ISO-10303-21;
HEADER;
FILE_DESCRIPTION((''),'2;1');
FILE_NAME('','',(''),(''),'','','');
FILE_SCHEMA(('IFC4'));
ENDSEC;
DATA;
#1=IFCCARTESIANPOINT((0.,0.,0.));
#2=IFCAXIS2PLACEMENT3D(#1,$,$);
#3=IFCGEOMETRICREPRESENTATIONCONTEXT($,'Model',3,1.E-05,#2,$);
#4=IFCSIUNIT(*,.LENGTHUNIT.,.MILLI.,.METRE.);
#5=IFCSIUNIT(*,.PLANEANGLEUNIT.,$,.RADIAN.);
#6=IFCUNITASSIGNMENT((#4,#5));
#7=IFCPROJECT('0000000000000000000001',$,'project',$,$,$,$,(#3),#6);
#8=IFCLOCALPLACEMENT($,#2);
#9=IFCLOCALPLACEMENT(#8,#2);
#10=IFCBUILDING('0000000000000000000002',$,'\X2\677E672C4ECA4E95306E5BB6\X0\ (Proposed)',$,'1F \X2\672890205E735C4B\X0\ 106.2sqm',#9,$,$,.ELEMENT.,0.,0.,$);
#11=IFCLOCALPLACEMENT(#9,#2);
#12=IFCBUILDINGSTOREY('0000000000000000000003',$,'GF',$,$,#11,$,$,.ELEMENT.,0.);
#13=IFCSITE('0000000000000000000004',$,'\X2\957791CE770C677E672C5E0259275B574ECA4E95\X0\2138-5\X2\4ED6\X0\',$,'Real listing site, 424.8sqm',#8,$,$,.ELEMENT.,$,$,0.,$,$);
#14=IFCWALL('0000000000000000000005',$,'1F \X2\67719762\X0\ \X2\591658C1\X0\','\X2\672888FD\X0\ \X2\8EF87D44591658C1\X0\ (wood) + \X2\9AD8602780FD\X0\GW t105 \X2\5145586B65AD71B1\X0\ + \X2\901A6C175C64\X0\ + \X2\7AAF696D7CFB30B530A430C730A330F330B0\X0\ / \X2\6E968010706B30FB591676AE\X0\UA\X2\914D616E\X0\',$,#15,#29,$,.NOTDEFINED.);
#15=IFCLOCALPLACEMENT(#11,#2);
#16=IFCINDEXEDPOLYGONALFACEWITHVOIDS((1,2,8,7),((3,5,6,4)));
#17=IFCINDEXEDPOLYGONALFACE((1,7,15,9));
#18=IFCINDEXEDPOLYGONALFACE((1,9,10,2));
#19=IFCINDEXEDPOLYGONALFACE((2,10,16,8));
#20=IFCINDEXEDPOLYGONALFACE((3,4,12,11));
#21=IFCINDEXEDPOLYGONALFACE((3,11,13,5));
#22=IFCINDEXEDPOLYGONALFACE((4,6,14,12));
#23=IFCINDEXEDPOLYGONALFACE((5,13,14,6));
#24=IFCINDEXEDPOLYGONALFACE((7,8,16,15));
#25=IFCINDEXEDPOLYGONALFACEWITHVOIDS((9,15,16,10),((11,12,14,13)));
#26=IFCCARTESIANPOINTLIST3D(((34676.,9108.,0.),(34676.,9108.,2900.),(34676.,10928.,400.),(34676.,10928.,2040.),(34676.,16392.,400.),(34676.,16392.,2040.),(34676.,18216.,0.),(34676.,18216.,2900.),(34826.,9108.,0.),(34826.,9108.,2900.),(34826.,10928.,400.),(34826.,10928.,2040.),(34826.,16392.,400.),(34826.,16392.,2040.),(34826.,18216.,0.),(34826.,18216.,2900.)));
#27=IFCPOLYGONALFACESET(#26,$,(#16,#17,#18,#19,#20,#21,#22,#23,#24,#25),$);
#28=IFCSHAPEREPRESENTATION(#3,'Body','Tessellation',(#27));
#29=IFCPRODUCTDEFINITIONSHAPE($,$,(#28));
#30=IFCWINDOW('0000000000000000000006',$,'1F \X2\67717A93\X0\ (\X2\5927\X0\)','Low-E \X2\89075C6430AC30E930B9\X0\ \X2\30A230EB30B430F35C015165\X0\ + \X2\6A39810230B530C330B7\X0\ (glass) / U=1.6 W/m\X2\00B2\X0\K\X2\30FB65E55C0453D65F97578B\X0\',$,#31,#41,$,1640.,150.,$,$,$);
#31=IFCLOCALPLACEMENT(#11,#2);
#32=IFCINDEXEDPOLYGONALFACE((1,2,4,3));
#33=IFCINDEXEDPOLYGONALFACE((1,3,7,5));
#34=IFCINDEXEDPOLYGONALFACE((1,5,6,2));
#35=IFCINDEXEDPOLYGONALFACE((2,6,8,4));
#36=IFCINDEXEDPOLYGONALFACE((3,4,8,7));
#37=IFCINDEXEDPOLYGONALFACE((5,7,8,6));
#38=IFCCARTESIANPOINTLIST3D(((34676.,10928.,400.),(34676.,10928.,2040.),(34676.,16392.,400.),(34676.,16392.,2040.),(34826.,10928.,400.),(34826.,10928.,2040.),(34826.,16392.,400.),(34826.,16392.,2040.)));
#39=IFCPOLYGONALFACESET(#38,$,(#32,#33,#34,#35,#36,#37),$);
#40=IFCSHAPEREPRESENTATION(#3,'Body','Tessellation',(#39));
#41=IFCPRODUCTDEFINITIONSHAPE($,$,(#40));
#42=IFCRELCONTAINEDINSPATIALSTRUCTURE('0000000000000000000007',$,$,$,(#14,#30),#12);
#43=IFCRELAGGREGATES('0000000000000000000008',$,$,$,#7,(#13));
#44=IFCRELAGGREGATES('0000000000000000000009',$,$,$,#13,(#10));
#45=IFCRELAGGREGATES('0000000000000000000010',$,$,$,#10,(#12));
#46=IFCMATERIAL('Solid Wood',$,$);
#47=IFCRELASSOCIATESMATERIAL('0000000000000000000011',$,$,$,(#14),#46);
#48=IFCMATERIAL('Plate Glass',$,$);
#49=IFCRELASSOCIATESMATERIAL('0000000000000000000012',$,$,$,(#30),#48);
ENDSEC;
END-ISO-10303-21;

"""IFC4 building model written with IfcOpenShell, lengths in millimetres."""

from ifc_helpers import new_model, si_unit, frame, frame_2d, origin, place, context, project, spatial, rectangle, extrude, material, element, fill, save


model = new_model("IFC4")

# Units and contexts
model_context = context("Model", 3, precision=1e-05, world=origin())
ifc_project = project(units=[si_unit("LENGTHUNIT", "METRE", prefix="MILLI"), si_unit("PLANEANGLEUNIT", "RADIAN")], contexts=[model_context])

# Site, building, storey
site_placement = place(None, origin())
site = spatial("IfcSite", under=ifc_project, at=site_placement, Name="長野県松本市大字今井2138-5他", ObjectType="Real listing site, 424.8sqm", CompositionType="ELEMENT", RefElevation=0.0)
building_placement = place(site_placement, origin())
building = spatial("IfcBuilding", under=site, at=building_placement, Name="松本今井の家 (Proposed)", ObjectType="1F 木造平屋 106.2sqm", CompositionType="ELEMENT", ElevationOfRefHeight=0.0, ElevationOfTerrain=0.0)
storey_placement = place(building_placement, origin())
storey = spatial("IfcBuildingStorey", under=building, at=storey_placement, Name="GF", CompositionType="ELEMENT", Elevation=0.0)

# Wall, opening, window
ifc_material_1 = material(Name="Solid Wood")
wall_1_placement = place(storey_placement, frame((17338.0, 4554.0, 0.0)))
wall_1 = element("IfcWall", 1, at=wall_1_placement, inside=storey, material=ifc_material_1, Name="1F 東面 外壁", Description="木製 軸組外壁 (wood) + 高性能GW t105 充填断熱 + 通気層 + 窯業系サイディング / 準耐火・外皮UA配慮", PredefinedType="NOTDEFINED", context=model_context, shape_type="SweptSolid", body=[
    extrude(rectangle(XDim=150.0, YDim=9108.0, at=frame_2d((75.0, 4554.0))), frame((17338.0, 4554.0, 0.0)), (0.0, 0.0, 1.0), 2900.0),
])
opening_1_placement = place(storey_placement, frame((17338.0, 5464.0, 200.0)))
opening_1 = element("IfcOpeningElement", 2, at=opening_1_placement, cuts=wall_1, PredefinedType="NOTDEFINED", context=model_context, shape_type="SweptSolid", body=[
    extrude(rectangle(XDim=150.0, YDim=5464.0, at=frame_2d((75.0, 2732.0))), frame((17338.0, 5464.0, 200.0)), (0.0, 0.0, 1.0), 1640.0),
])
ifc_material_2 = material(Name="Plate Glass")
window_1_placement = place(storey_placement, frame((17338.0, 5464.0, 200.0)))
window_1 = element("IfcWindow", 3, at=window_1_placement, inside=storey, material=ifc_material_2, Name="1F 東窓 (大)", Description="Low-E 複層ガラス アルゴン封入 + 樹脂サッシ (glass) / U=1.6 W/m²K・日射取得型", OverallHeight=1640.0, OverallWidth=150.0, context=model_context, shape_type="SweptSolid", body=[
    extrude(rectangle(XDim=150.0, YDim=5464.0, at=frame_2d((75.0, 2732.0))), frame((17338.0, 5464.0, 200.0)), (0.0, 0.0, 1.0), 1640.0),
])
fill(opening_1, window_1)

save(model, "model.ifc")
